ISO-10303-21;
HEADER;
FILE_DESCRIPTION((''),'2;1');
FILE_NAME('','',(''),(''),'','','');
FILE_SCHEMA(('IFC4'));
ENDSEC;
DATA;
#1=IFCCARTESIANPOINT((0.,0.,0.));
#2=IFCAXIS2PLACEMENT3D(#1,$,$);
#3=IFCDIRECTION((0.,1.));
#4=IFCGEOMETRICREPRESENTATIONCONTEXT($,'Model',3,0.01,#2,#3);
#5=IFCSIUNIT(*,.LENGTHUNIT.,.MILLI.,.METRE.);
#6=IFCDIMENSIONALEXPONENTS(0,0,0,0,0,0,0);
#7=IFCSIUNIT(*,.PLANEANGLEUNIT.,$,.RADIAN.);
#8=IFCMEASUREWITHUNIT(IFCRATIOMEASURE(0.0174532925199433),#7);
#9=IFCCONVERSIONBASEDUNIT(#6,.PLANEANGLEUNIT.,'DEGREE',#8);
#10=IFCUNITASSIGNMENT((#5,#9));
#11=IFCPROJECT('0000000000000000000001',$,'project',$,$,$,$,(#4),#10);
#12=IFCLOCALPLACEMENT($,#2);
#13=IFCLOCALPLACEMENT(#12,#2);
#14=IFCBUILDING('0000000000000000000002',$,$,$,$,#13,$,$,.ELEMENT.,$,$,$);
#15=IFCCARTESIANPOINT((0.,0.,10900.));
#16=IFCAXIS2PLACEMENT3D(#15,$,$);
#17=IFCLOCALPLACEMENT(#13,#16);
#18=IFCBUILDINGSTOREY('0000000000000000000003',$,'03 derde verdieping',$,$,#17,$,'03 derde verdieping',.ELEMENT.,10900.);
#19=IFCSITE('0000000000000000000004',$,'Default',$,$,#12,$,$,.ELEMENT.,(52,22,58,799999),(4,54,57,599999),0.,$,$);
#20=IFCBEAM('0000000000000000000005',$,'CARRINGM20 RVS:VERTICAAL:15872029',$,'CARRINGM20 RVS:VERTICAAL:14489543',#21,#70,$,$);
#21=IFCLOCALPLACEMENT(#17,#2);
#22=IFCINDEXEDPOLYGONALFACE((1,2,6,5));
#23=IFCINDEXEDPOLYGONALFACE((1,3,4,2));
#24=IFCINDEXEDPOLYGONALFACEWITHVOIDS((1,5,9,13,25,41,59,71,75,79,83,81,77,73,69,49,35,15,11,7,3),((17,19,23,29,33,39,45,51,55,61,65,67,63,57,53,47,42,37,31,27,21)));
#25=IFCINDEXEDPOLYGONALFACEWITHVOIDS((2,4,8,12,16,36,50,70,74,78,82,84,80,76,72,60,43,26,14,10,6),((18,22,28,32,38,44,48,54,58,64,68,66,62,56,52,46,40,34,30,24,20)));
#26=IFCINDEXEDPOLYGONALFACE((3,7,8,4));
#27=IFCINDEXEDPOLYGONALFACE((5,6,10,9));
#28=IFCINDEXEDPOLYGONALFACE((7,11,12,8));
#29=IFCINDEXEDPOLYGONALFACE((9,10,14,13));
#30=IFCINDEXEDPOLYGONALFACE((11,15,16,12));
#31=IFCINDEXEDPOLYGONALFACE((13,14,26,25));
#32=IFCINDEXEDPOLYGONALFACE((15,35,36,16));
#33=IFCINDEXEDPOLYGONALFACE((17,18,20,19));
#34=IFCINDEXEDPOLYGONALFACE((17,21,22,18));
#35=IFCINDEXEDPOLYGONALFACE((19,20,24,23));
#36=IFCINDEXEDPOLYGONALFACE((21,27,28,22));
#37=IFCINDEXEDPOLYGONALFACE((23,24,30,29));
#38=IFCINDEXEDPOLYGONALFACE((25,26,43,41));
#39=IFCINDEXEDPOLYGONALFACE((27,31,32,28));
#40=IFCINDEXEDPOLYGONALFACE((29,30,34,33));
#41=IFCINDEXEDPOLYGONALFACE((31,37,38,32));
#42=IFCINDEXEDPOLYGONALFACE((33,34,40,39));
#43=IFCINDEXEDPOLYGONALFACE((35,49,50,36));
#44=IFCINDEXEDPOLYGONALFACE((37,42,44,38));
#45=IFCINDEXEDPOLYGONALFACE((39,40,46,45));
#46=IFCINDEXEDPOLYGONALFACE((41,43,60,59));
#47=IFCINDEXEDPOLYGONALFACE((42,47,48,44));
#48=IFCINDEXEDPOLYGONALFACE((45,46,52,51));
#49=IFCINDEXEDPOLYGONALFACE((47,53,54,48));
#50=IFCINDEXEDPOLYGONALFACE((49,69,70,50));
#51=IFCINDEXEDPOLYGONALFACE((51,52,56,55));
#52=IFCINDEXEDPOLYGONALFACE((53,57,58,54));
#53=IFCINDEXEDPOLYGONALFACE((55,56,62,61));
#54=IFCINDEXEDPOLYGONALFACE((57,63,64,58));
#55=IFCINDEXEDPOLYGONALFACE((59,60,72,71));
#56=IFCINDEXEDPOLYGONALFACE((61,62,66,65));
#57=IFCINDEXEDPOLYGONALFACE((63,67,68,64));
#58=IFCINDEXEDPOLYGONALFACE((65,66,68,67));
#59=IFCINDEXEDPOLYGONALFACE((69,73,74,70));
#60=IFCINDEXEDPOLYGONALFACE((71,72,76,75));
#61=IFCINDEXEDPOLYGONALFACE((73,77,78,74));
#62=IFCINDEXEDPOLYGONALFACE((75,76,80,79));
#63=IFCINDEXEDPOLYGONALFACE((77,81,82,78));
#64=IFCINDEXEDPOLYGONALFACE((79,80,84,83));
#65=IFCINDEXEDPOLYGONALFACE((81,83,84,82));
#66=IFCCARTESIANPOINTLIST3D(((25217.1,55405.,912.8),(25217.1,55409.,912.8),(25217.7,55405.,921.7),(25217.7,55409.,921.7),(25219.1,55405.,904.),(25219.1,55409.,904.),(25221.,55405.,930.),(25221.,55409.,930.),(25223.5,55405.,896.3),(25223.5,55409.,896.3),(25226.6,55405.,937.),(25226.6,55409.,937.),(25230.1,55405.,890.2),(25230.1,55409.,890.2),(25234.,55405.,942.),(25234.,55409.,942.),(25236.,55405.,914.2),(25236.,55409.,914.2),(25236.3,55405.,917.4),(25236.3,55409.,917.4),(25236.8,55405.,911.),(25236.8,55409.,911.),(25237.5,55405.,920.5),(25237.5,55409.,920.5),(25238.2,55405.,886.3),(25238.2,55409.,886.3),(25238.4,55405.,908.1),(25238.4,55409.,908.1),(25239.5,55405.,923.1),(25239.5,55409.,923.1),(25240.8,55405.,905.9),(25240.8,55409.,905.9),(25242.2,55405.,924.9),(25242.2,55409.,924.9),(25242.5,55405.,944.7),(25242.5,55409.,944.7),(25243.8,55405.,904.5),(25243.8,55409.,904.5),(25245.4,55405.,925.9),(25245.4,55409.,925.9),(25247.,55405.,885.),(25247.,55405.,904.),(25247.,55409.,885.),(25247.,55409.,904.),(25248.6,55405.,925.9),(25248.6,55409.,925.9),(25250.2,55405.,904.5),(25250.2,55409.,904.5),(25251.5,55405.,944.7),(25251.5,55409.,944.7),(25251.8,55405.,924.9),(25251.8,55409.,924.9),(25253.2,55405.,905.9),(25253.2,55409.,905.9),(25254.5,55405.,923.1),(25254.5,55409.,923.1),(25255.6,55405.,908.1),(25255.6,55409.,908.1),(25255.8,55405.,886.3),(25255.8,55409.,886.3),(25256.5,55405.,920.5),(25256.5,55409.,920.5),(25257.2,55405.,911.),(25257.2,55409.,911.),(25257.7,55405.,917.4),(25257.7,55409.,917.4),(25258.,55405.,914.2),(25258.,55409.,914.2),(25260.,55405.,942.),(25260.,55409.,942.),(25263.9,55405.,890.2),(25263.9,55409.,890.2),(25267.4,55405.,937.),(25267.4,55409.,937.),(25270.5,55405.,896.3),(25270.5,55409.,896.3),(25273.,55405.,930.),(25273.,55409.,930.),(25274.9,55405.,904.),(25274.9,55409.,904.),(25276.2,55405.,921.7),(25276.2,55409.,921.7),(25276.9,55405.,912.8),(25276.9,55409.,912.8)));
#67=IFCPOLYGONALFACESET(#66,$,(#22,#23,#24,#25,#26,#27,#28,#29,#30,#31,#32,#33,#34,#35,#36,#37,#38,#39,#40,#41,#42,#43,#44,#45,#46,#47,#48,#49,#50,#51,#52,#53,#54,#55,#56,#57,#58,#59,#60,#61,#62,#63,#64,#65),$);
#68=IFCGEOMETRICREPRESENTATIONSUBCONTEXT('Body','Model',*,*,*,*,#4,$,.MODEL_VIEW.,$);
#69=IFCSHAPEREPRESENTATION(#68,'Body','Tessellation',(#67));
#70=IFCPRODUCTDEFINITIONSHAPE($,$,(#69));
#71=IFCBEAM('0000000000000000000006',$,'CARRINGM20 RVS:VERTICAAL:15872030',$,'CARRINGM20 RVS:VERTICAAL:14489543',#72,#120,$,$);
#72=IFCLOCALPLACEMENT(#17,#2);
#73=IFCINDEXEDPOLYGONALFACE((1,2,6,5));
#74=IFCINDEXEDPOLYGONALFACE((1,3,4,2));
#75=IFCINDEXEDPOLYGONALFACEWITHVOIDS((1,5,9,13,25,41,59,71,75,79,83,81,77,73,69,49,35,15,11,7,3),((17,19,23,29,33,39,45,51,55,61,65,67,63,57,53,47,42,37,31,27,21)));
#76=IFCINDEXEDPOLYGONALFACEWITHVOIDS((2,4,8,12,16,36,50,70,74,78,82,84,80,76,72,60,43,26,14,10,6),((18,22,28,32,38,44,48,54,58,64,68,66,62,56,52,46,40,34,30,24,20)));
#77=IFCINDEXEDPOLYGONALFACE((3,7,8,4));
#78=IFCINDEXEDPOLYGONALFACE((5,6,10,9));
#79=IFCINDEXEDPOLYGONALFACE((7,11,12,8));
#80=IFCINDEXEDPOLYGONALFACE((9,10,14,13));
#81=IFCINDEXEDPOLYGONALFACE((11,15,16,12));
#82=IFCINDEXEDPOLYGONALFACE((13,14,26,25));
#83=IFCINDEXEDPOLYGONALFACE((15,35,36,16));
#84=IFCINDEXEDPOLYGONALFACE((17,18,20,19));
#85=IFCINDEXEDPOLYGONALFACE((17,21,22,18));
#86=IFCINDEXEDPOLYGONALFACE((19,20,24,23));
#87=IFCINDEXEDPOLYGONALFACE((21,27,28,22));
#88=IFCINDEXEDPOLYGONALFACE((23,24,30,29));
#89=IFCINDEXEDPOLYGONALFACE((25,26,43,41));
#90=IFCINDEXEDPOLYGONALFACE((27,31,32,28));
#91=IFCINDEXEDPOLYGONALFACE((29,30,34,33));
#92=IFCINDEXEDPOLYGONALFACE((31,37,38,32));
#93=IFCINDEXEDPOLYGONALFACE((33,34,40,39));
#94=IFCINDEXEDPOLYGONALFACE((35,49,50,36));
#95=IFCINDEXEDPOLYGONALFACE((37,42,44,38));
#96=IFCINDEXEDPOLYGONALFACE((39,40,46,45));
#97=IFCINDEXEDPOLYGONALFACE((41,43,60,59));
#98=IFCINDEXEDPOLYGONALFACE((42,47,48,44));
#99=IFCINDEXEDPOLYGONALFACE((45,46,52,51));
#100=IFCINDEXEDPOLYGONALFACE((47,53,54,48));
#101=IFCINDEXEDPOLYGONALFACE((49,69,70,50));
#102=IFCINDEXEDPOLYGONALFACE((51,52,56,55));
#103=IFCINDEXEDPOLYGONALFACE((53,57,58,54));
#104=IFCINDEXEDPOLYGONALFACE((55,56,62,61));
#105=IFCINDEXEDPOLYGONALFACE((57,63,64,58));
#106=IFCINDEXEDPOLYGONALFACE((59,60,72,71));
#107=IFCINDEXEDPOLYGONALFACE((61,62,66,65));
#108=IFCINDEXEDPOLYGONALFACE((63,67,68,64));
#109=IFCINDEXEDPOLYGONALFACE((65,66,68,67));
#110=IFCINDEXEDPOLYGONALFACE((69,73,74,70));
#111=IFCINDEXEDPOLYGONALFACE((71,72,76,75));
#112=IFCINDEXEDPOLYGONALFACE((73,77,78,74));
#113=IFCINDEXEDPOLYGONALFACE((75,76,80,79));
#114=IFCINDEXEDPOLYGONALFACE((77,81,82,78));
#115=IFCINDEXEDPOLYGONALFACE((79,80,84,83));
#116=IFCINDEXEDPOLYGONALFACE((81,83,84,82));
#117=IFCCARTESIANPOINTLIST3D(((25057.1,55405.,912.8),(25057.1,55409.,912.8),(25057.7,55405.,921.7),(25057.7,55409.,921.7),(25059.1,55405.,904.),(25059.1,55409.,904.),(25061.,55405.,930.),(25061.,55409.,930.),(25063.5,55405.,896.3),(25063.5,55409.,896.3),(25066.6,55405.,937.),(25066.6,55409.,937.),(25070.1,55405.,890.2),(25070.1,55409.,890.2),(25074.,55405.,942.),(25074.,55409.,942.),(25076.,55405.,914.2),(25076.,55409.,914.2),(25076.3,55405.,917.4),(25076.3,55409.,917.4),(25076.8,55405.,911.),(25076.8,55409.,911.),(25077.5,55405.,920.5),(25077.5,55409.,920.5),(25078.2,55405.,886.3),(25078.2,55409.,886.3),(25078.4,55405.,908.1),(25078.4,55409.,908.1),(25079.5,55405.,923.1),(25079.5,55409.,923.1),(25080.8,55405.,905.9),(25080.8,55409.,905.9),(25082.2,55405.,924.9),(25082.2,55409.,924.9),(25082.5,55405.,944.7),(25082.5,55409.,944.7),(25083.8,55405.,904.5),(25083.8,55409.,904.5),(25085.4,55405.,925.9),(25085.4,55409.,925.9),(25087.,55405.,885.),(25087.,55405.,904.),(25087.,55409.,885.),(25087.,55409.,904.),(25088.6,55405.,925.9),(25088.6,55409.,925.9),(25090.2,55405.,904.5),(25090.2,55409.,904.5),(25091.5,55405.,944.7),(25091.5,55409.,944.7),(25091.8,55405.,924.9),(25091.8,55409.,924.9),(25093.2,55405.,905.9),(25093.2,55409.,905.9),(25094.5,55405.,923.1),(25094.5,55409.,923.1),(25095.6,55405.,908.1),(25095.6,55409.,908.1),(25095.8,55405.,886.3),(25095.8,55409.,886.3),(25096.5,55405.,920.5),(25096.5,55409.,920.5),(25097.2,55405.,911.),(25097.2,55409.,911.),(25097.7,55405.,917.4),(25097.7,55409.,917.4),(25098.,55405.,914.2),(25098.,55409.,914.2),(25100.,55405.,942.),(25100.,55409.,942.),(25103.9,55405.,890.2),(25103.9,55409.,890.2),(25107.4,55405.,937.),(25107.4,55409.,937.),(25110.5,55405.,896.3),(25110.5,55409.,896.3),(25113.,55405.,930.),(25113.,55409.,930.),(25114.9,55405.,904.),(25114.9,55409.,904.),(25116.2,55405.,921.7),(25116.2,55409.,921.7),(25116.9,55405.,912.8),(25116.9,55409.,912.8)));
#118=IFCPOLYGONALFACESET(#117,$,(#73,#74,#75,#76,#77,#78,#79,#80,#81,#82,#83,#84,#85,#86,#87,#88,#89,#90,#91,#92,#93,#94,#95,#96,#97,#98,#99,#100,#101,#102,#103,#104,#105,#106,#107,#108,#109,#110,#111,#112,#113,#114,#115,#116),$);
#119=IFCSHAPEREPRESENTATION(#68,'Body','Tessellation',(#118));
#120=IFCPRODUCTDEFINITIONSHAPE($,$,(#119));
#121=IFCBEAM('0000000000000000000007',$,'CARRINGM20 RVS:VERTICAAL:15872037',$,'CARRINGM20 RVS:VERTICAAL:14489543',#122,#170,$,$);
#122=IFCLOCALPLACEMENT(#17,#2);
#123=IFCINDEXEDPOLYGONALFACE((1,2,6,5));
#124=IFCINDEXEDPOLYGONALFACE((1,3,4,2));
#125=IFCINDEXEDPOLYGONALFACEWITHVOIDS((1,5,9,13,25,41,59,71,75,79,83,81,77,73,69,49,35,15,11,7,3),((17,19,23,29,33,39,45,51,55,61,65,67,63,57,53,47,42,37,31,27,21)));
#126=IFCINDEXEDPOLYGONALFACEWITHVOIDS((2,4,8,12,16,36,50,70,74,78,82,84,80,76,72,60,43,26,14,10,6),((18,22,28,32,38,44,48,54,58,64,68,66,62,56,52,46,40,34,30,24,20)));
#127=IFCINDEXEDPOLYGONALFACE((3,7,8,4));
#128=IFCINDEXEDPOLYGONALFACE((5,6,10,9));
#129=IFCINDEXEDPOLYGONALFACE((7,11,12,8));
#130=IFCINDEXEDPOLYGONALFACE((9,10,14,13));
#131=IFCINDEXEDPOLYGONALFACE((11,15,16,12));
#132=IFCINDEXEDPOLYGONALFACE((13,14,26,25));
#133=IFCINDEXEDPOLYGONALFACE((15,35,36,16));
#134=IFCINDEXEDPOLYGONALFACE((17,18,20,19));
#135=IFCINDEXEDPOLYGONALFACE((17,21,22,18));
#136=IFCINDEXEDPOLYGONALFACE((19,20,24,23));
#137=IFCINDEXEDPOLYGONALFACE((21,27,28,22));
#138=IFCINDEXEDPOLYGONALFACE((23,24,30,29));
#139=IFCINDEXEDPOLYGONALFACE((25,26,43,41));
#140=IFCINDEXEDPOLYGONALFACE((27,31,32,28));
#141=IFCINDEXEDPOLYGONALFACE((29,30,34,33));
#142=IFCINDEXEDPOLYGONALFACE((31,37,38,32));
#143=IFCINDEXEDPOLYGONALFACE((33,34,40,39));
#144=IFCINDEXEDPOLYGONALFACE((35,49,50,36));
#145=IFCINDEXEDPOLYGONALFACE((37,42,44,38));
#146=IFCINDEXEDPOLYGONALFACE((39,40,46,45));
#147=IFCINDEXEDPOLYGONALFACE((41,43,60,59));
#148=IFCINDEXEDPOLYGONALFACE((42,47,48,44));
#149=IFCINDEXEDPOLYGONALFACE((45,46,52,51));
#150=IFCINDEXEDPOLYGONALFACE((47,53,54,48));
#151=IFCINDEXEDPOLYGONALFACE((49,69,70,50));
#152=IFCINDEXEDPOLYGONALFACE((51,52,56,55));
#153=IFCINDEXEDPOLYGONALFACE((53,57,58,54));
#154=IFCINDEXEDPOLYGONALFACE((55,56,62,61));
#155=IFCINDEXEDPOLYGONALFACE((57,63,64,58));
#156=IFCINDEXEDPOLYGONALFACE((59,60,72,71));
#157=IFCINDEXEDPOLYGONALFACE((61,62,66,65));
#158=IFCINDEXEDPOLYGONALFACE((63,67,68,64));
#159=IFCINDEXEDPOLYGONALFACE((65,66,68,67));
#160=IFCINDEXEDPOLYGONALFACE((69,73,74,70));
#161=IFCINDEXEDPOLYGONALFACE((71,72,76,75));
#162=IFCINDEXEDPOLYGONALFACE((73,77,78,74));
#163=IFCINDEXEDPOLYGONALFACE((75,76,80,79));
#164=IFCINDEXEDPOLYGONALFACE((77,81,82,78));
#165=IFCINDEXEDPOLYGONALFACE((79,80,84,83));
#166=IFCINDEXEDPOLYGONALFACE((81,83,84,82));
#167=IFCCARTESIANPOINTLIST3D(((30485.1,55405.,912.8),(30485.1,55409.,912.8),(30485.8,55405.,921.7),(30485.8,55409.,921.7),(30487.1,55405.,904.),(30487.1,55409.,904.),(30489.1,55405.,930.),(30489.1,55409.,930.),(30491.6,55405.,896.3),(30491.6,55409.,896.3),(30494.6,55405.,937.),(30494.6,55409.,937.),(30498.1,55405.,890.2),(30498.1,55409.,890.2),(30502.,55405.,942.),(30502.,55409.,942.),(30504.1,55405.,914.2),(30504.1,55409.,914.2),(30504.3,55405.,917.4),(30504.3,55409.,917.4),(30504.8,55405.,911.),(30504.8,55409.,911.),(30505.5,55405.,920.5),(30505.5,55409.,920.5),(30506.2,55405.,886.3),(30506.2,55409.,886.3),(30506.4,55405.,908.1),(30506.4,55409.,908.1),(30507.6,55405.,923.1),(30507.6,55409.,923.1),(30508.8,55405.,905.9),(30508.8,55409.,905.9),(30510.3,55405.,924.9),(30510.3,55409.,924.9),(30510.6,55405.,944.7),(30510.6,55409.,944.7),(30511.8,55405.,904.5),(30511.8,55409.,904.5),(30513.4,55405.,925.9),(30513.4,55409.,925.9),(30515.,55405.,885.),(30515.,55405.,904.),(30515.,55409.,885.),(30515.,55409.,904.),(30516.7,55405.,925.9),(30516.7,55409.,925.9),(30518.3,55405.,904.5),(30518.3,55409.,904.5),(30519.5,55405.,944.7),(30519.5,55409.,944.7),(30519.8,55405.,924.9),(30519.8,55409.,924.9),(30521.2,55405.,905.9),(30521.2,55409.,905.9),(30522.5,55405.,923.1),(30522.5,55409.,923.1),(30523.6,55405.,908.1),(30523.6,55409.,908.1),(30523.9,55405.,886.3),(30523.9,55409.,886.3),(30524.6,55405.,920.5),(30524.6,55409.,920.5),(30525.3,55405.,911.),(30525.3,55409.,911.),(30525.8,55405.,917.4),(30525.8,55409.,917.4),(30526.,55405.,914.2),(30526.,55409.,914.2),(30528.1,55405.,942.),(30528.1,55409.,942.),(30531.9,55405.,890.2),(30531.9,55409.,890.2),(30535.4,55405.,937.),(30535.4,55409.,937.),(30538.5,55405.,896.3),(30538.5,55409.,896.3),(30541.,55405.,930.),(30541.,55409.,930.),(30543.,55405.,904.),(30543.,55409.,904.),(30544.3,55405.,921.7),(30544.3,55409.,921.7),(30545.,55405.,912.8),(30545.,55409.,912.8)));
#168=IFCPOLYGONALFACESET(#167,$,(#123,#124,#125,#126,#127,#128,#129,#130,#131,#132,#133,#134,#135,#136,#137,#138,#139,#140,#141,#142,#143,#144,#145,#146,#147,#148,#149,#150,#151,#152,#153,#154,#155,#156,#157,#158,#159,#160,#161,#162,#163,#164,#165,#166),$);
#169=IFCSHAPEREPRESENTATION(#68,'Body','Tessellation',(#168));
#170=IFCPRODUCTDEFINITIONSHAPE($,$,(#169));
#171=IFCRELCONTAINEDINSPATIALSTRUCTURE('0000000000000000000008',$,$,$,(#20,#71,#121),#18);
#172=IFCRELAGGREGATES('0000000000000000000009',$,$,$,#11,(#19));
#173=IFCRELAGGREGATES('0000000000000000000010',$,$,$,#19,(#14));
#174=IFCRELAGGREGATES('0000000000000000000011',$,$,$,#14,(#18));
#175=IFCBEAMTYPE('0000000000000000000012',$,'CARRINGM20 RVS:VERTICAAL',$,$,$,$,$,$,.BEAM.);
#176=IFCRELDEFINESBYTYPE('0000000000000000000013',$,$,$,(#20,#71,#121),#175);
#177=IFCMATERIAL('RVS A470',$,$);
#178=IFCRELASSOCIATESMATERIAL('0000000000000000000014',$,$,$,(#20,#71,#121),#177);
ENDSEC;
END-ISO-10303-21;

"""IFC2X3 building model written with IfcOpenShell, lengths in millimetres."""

from ifc_helpers import new_model, entity, si_unit, converted_unit, direction, frame, origin, origin_2d_with_axis, place, context, subcontext, project, spatial, hollow_circle, extrude, material, type_object, element, save


model = new_model("IFC2X3")

# Units and contexts
model_context = context("Model", 3, precision=0.01, world=origin(), true_north=direction((0.0, 1.0)))
body_context = subcontext(model_context, "Body", "Model", "MODEL_VIEW")
ifc_project = project(units=[si_unit("LENGTHUNIT", "METRE", prefix="MILLI"), converted_unit("PLANEANGLEUNIT", "DEGREE", entity("IfcRatioMeasure", 0.0174532925199433), si_unit("PLANEANGLEUNIT", "RADIAN"), dimensions=[0, 0, 0, 0, 0, 0, 0])], contexts=[model_context])

# Site, building, storey
site_placement = place(None, origin())
site = spatial("IfcSite", under=ifc_project, at=site_placement, Name="Default", CompositionType="ELEMENT", RefLatitude=(52, 22, 58, 799999), RefLongitude=(4, 54, 57, 599999), RefElevation=0.0)
building_placement = place(site_placement, origin())
building = spatial("IfcBuilding", under=site, at=building_placement, CompositionType="ELEMENT")
storey_placement = place(building_placement, frame((0.0, 0.0, 10900.0)))
storey = spatial("IfcBuildingStorey", under=building, at=storey_placement, Name="03 derde verdieping", LongName="03 derde verdieping", CompositionType="ELEMENT", Elevation=10900.0)

# Beams
ifc_material_1 = material(Name="RVS A470")
beam_type_1 = type_object("IfcBeamType", Name="CARRINGM20 RVS:VERTICAAL", PredefinedType="BEAM")
beam_1_placement = place(storey_placement, origin())
element("IfcBeam", 1, at=beam_1_placement, inside=storey, type_object=beam_type_1, material=ifc_material_1, Name="CARRINGM20 RVS:VERTICAAL:15872029", ObjectType="CARRINGM20 RVS:VERTICAAL:14489543", context=body_context, shape_type="SweptSolid", body=[
    extrude(hollow_circle(Radius=30.0, WallThickness=19.0, at=origin_2d_with_axis()), frame((25247.0, 55405.0, 915.0), z_axis=(0.0, 1.0, 0.0), x_axis=(0.0, 0.0, -1.0)), (0.0, 0.0, 1.0), 4.0),
])
beam_2_placement = place(storey_placement, origin())
element("IfcBeam", 2, at=beam_2_placement, inside=storey, type_object=beam_type_1, material=ifc_material_1, Name="CARRINGM20 RVS:VERTICAAL:15872030", ObjectType="CARRINGM20 RVS:VERTICAAL:14489543", context=body_context, shape_type="SweptSolid", body=[
    extrude(hollow_circle(Radius=30.0, WallThickness=19.0, at=origin_2d_with_axis()), frame((25087.0, 55405.0, 915.0), z_axis=(0.0, 1.0, 0.0), x_axis=(0.0, 0.0, -1.0)), (0.0, 0.0, 1.0), 4.0),
])
beam_3_placement = place(storey_placement, origin())
element("IfcBeam", 3, at=beam_3_placement, inside=storey, type_object=beam_type_1, material=ifc_material_1, Name="CARRINGM20 RVS:VERTICAAL:15872037", ObjectType="CARRINGM20 RVS:VERTICAAL:14489543", context=body_context, shape_type="SweptSolid", body=[
    extrude(hollow_circle(Radius=30.0, WallThickness=19.0, at=origin_2d_with_axis()), frame((30515.0, 55405.0, 915.0), z_axis=(0.0, 1.0, 0.0), x_axis=(0.0, 0.0, -1.0)), (0.0, 0.0, 1.0), 4.0),
])

save(model, "model.ifc")
